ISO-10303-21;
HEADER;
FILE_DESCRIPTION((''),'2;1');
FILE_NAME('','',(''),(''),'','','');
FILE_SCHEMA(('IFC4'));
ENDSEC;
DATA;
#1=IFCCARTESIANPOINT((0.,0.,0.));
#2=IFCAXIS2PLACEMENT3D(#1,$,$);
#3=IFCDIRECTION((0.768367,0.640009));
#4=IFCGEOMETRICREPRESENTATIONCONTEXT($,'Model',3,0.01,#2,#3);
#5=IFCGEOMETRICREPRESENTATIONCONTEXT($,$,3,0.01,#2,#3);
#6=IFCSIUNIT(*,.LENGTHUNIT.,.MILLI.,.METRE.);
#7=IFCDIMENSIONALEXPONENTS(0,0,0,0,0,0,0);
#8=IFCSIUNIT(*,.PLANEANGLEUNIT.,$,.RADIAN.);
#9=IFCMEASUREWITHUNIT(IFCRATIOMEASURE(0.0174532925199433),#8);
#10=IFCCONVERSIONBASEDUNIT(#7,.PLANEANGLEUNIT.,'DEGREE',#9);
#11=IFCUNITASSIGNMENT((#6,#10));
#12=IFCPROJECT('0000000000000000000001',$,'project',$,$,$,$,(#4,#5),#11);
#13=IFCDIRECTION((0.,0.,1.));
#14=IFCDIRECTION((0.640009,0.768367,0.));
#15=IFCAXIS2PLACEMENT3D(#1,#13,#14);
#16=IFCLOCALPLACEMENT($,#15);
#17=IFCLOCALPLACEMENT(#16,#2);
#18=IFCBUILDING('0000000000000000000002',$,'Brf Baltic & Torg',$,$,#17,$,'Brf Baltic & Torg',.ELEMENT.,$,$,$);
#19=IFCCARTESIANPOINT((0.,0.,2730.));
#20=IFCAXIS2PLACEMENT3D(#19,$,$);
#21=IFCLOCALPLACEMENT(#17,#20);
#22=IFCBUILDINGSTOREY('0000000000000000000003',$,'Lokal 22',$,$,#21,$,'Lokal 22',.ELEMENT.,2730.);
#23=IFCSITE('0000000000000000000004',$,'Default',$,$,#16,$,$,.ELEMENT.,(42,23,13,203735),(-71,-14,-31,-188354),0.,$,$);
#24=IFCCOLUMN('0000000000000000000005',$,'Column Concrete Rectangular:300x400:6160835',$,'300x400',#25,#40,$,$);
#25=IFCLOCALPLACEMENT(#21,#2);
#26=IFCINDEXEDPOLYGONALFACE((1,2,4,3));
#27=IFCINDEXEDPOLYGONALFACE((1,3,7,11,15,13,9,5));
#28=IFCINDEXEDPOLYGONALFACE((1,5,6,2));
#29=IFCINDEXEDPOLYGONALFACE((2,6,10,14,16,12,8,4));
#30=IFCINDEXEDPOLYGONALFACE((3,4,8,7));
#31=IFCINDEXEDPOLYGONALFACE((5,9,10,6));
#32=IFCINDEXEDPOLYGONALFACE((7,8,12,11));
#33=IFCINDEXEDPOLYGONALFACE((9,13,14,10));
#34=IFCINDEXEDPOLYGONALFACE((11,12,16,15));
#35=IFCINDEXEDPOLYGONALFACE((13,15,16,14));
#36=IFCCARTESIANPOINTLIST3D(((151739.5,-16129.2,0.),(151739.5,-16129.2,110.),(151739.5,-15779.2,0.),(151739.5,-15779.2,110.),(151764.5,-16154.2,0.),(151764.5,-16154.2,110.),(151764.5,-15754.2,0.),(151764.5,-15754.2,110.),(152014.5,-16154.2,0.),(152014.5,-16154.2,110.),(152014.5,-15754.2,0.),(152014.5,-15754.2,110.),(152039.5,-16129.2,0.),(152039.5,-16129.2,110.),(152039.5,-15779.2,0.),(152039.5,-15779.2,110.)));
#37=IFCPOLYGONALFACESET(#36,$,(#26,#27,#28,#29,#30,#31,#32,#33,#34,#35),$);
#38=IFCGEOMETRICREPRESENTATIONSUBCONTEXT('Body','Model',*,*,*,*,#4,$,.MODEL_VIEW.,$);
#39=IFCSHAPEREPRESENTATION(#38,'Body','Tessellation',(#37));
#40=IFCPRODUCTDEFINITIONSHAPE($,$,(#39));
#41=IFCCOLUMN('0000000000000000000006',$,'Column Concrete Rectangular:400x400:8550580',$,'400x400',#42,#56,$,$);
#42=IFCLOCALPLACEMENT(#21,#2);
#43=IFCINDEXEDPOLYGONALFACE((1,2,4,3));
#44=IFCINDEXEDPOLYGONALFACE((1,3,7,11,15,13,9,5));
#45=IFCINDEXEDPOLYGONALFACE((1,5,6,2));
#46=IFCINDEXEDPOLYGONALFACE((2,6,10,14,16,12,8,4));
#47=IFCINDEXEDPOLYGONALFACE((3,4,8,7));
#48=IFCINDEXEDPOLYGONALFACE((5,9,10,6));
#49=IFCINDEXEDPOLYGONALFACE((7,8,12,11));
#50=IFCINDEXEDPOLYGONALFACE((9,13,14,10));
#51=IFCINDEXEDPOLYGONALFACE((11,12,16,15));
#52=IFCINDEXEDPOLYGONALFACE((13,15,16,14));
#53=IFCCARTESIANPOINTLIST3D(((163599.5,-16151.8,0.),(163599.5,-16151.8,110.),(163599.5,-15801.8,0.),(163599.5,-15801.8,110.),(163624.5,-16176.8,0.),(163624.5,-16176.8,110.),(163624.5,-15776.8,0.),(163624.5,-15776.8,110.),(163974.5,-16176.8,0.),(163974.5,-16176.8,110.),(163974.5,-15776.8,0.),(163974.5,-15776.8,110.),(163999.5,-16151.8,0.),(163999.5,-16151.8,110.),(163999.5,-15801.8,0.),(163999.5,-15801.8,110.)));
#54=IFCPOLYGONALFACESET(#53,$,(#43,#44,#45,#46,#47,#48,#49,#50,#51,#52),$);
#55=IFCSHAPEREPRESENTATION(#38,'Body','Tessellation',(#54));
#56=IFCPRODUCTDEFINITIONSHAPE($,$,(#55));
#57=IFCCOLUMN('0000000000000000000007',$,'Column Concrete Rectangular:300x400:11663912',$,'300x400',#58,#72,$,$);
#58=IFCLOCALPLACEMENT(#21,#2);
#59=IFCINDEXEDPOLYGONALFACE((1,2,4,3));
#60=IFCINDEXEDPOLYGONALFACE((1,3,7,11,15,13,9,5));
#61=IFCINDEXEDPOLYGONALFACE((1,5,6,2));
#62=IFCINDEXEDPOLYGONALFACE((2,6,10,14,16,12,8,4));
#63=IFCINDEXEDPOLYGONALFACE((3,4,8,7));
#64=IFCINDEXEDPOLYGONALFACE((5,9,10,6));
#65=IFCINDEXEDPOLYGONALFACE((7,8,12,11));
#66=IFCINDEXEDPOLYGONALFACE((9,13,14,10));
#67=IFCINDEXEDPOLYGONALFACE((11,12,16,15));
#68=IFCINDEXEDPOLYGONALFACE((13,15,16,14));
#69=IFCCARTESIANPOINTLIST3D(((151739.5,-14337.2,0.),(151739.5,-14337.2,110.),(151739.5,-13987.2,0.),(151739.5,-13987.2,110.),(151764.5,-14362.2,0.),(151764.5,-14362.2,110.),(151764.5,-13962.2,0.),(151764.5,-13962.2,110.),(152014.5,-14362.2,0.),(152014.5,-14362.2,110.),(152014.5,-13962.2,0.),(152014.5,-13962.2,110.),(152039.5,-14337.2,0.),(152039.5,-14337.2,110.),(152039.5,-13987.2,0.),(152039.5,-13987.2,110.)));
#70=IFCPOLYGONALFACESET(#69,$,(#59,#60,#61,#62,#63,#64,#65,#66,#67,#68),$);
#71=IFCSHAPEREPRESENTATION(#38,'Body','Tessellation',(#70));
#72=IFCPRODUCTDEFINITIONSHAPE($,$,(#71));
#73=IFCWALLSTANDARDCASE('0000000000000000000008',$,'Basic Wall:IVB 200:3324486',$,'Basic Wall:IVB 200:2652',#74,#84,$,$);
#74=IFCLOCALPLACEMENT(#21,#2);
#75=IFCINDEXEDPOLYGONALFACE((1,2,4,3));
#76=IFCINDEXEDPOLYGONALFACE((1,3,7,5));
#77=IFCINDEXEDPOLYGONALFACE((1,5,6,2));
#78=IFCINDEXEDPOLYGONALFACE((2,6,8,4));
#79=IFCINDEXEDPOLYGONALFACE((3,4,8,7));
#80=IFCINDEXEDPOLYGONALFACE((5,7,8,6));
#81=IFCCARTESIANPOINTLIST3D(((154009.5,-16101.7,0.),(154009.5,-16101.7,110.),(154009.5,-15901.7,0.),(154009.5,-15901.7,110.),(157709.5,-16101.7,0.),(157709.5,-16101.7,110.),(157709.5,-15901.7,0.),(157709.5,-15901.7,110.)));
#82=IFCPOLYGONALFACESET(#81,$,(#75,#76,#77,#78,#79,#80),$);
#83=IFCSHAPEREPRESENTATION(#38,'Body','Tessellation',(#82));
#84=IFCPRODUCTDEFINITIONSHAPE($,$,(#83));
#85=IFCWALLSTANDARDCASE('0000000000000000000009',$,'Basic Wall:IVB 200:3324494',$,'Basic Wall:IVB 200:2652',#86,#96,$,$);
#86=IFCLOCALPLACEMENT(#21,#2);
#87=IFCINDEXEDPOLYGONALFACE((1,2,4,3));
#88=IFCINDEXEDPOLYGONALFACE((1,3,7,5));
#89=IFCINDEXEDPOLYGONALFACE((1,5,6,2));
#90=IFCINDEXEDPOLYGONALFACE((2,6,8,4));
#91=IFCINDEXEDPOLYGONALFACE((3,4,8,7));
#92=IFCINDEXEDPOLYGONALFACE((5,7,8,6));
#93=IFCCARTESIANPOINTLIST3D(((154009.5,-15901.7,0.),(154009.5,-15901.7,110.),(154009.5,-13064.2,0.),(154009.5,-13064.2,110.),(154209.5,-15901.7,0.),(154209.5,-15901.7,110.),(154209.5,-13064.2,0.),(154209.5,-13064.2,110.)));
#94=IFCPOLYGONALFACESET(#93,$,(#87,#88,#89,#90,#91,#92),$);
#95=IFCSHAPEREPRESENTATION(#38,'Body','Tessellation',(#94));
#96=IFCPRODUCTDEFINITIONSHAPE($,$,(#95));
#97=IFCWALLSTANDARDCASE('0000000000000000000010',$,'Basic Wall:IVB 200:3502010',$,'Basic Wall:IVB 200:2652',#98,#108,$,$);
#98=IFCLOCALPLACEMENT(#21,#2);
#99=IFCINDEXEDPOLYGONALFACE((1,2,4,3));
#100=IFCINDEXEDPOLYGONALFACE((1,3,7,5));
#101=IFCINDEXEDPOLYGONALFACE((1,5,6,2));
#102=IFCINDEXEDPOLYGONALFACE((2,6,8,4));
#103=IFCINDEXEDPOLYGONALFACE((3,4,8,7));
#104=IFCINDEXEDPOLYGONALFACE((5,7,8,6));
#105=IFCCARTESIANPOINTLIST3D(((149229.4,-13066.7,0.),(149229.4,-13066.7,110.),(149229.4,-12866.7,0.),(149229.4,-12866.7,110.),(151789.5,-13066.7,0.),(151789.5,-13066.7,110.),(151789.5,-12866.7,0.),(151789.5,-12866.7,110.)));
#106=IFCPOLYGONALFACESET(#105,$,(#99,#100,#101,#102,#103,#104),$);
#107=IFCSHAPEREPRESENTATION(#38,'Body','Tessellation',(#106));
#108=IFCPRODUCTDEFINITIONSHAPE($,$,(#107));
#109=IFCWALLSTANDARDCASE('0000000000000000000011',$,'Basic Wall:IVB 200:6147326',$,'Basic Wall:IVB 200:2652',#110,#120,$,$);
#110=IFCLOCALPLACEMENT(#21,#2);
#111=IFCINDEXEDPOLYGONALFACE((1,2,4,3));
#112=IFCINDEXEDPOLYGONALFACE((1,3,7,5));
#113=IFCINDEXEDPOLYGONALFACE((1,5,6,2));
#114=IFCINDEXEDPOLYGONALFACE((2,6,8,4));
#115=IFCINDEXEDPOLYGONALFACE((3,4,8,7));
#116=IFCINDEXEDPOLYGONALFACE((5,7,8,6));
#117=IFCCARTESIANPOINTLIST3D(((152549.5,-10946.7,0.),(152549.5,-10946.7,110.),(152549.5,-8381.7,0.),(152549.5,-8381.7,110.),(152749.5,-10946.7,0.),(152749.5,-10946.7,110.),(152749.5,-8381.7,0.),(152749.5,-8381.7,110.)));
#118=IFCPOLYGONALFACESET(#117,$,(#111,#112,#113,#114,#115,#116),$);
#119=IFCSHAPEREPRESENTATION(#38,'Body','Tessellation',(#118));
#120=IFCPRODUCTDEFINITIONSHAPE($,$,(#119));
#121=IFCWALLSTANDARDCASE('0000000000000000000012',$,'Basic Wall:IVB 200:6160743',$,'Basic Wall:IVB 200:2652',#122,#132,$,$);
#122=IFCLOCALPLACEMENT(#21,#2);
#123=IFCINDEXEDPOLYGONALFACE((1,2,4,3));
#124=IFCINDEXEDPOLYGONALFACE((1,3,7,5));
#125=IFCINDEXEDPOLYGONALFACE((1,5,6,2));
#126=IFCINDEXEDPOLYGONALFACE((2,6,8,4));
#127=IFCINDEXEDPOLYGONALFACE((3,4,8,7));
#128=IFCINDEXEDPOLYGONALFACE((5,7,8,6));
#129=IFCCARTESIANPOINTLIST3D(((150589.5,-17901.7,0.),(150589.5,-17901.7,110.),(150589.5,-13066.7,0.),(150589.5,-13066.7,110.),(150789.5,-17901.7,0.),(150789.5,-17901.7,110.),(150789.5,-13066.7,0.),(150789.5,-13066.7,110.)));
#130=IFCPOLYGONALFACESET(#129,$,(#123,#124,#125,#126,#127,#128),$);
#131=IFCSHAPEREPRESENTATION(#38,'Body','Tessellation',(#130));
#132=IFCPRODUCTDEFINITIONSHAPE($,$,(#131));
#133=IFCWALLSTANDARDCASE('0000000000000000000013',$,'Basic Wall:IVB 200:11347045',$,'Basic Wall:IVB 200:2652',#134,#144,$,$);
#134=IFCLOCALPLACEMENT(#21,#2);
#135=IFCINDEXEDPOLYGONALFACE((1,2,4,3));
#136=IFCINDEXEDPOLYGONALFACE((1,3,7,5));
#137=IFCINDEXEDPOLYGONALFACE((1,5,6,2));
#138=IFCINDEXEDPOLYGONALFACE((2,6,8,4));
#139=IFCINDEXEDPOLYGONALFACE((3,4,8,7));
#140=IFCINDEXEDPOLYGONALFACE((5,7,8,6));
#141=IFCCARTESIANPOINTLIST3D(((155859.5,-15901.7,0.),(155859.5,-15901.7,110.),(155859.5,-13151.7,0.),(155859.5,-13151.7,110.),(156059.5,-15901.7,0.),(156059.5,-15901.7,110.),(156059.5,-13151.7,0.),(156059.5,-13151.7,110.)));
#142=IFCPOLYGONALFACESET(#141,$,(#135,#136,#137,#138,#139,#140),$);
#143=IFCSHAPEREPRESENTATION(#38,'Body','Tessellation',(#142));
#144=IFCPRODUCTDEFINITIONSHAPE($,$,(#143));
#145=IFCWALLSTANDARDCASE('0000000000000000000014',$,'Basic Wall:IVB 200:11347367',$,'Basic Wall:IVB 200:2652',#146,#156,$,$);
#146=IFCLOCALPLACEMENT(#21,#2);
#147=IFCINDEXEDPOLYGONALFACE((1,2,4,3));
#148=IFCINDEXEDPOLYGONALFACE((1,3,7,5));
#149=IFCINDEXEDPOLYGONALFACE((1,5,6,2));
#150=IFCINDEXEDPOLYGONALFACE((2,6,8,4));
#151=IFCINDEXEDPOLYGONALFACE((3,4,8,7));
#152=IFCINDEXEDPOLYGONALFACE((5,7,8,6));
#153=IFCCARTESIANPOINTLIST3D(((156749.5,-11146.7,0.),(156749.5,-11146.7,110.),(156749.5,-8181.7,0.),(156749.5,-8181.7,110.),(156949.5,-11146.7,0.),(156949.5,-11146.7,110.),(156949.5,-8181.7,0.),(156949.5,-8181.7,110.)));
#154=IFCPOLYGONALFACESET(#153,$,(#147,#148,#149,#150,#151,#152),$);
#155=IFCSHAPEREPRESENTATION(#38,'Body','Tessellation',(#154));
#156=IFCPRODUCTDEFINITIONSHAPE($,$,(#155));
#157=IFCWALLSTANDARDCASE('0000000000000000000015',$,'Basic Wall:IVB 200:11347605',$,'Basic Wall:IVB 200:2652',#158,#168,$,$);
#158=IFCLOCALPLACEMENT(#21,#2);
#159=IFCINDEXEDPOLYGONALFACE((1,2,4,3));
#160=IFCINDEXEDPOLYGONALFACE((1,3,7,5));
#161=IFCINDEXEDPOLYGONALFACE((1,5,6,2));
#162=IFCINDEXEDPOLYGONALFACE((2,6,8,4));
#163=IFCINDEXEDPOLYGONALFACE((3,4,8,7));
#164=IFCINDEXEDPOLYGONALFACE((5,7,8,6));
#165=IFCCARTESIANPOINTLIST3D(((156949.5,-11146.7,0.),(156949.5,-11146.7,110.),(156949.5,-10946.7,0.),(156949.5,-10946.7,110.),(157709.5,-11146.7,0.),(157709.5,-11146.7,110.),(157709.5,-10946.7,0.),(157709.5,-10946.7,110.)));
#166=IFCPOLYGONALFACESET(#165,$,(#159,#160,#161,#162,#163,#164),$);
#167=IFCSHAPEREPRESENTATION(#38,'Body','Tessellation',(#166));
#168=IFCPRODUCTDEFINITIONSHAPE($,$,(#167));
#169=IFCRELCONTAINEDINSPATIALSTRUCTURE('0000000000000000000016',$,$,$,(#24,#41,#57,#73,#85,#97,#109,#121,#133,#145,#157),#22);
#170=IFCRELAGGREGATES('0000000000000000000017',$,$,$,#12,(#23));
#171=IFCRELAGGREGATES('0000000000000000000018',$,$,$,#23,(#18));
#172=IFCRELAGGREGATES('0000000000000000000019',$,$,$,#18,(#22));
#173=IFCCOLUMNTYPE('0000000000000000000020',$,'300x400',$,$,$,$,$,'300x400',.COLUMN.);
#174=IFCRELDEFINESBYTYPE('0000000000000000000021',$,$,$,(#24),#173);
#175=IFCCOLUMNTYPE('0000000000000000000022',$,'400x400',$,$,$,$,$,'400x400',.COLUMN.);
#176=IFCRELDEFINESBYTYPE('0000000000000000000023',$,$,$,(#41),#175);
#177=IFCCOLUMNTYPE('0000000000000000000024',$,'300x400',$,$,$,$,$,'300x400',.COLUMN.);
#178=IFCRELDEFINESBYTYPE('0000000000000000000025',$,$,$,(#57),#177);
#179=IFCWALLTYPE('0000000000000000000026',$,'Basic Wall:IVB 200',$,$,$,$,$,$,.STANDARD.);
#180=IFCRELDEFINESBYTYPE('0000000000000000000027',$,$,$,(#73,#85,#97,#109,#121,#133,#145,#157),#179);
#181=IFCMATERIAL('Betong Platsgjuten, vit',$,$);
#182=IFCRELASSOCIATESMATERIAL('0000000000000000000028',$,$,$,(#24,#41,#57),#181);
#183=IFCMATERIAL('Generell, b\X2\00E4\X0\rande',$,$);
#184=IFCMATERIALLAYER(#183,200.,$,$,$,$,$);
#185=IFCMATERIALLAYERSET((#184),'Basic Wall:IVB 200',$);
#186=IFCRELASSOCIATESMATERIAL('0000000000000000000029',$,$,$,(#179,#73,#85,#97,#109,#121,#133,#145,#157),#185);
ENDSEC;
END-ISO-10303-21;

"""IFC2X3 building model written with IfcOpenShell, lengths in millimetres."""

from ifc_helpers import new_model, entity, si_unit, converted_unit, direction, frame, frame_2d, origin, place, context, subcontext, project, spatial, polyline, rectangle, outline, extrude, clip, halfspace, source, transform, mapped, material, layer, layer_set, layer_usage, type_object, type_shapes, element, save


model = new_model("IFC2X3")

# Units and contexts
model_context = context("Model", 3, precision=0.01, world=origin(), true_north=direction((0.768367, 0.640009)))
context_of_model = context(None, 3, precision=0.01, world=origin(), true_north=direction((0.768367, 0.640009)))
body_context = subcontext(model_context, "Body", "Model", "MODEL_VIEW")
ifc_project = project(units=[si_unit("LENGTHUNIT", "METRE", prefix="MILLI"), converted_unit("PLANEANGLEUNIT", "DEGREE", entity("IfcRatioMeasure", 0.0174532925199433), si_unit("PLANEANGLEUNIT", "RADIAN"), dimensions=[0, 0, 0, 0, 0, 0, 0])], contexts=[model_context, context_of_model])

# Site, building, storey
site_placement = place(None, frame((0.0, 0.0, 0.0), z_axis=(0.0, 0.0, 1.0), x_axis=(0.640009, 0.768367, 0.0)))
site = spatial("IfcSite", under=ifc_project, at=site_placement, Name="Default", CompositionType="ELEMENT", RefLatitude=(42, 23, 13, 203735), RefLongitude=(-71, -14, -31, -188354), RefElevation=0.0)
building_placement = place(site_placement, origin())
building = spatial("IfcBuilding", under=site, at=building_placement, Name="Brf Baltic & Torg", LongName="Brf Baltic & Torg", CompositionType="ELEMENT")
storey_placement = place(building_placement, frame((0.0, 0.0, 2730.0)))
storey = spatial("IfcBuildingStorey", under=building, at=storey_placement, Name="Lokal 22", LongName="Lokal 22", CompositionType="ELEMENT", Elevation=2730.0)

# Columns
ifc_material_1 = material(Name="Betong Platsgjuten, vit")
column_type_1 = type_object("IfcColumnType", Name="300x400", ElementType="300x400", PredefinedType="COLUMN")
shared_shape_1 = source(origin(), body_context, "Body", "SweptSolid", [
    extrude(outline(polyline([(-175.0, -150.0), (175.0, -150.0), (200.0, -125.0), (200.0, 125.0), (175.0, 150.0), (-175.0, 150.0), (-200.0, 125.0), (-200.0, -125.0), (-175.0, -150.0)])), frame((0.0, 0.0, 2730.0), z_axis=(0.0, 0.0, 1.0), x_axis=(0.0, -1.0, 0.0)), (0.0, 0.0, 1.0), 110.0),
])
type_shapes(column_type_1, [shared_shape_1])
column_1_placement = place(storey_placement, frame((151889.5, -15954.2, -2730.0)))
element("IfcColumn", 1, at=column_1_placement, inside=storey, type_object=column_type_1, material=ifc_material_1, Name="Column Concrete Rectangular:300x400:6160835", ObjectType="300x400", context=body_context, shape_type="MappedRepresentation", body=[
    mapped(shared_shape_1, transform((0.0, 0.0, 0.0), scale=1.0)),
])
column_type_2 = type_object("IfcColumnType", Name="400x400", ElementType="400x400", PredefinedType="COLUMN")
shared_shape_2 = source(origin(), body_context, "Body", "SweptSolid", [
    extrude(outline(polyline([(-175.0, -200.0), (175.0, -200.0), (200.0, -175.0), (200.0, 175.0), (175.0, 200.0), (-175.0, 200.0), (-200.0, 175.0), (-200.0, -175.0), (-175.0, -200.0)])), frame((0.0, 0.0, 2730.0), z_axis=(0.0, 0.0, 1.0), x_axis=(0.0, -1.0, 0.0)), (0.0, 0.0, 1.0), 110.0),
])
type_shapes(column_type_2, [shared_shape_2])
column_2_placement = place(storey_placement, frame((163799.5, -15976.8, -2730.0)))
element("IfcColumn", 2, at=column_2_placement, inside=storey, type_object=column_type_2, material=ifc_material_1, Name="Column Concrete Rectangular:400x400:8550580", ObjectType="400x400", context=body_context, shape_type="MappedRepresentation", body=[
    mapped(shared_shape_2, transform((0.0, 0.0, 0.0), scale=1.0)),
])
column_type_3 = type_object("IfcColumnType", Name="300x400", ElementType="300x400", PredefinedType="COLUMN")
shared_shape_3 = source(origin(), body_context, "Body", "SweptSolid", [
    extrude(outline(polyline([(-175.0, -150.0), (175.0, -150.0), (200.0, -125.0), (200.0, 125.0), (175.0, 150.0), (-175.0, 150.0), (-200.0, 125.0), (-200.0, -125.0), (-175.0, -150.0)])), frame((0.0, 0.0, 2730.0), z_axis=(0.0, 0.0, 1.0), x_axis=(0.0, -1.0, 0.0)), (0.0, 0.0, 1.0), 110.0),
])
type_shapes(column_type_3, [shared_shape_3])
column_3_placement = place(storey_placement, frame((151889.5, -14162.2, -2730.0)))
element("IfcColumn", 3, at=column_3_placement, inside=storey, type_object=column_type_3, material=ifc_material_1, Name="Column Concrete Rectangular:300x400:11663912", ObjectType="300x400", context=body_context, shape_type="MappedRepresentation", body=[
    mapped(shared_shape_3, transform((0.0, 0.0, 0.0), scale=1.0)),
])

# Walls
ifc_material_2 = material(Name="Generell, bärande")
ifc_layer = layer(ifc_material_2, 200.0)
ifc_layer_set = layer_set([ifc_layer], Name="Basic Wall:IVB 200")
ifc_layer_usage_1 = layer_usage(ifc_layer_set, "AXIS2", "NEGATIVE", 100.0)
wall_type = type_object("IfcWallType", Name="Basic Wall:IVB 200", PredefinedType="STANDARD", material=ifc_layer_set)
wall_1_placement = place(storey_placement, frame((157709.5, -16001.7, 0.0), z_axis=(0.0, 0.0, 1.0), x_axis=(-1.0, 0.0, 0.0)))
element("IfcWallStandardCase", 4, at=wall_1_placement, inside=storey, type_object=wall_type, material=ifc_layer_usage_1, Name="Basic Wall:IVB 200:3324486", ObjectType="Basic Wall:IVB 200:2652", context=body_context, shape_type="Clipping", body=[
    clip(extrude(rectangle(XDim=3700.0, YDim=200.0, at=frame_2d((1850.0, 0.0), x_axis=(-1.0, 0.0))), origin(), (0.0, 0.0, 1.0), 110.0), halfspace(frame((0.0, 0.0, -1080.0)), True)),
])
ifc_layer_usage_2 = layer_usage(ifc_layer_set, "AXIS2", "NEGATIVE", 100.0)
wall_2_placement = place(storey_placement, frame((154109.5, -15901.7, 0.0), z_axis=(0.0, 0.0, 1.0), x_axis=(0.0, 1.0, 0.0)))
element("IfcWallStandardCase", 5, at=wall_2_placement, inside=storey, type_object=wall_type, material=ifc_layer_usage_2, Name="Basic Wall:IVB 200:3324494", ObjectType="Basic Wall:IVB 200:2652", context=body_context, shape_type="Clipping", body=[
    clip(extrude(rectangle(XDim=2837.5, YDim=200.0, at=frame_2d((1418.7, 0.0), x_axis=(-1.0, 0.0))), origin(), (0.0, 0.0, 1.0), 110.0), halfspace(frame((0.0, 0.0, -1080.0)), True)),
])

# Wall
ifc_layer_usage_3 = layer_usage(ifc_layer_set, "AXIS2", "NEGATIVE", 100.0)
wall_3_placement = place(storey_placement, frame((151789.5, -12966.7, 0.0), z_axis=(0.0, 0.0, 1.0), x_axis=(-1.0, 0.0, 0.0)))
element("IfcWallStandardCase", 6, at=wall_3_placement, inside=storey, type_object=wall_type, material=ifc_layer_usage_3, Name="Basic Wall:IVB 200:3502010", ObjectType="Basic Wall:IVB 200:2652", context=body_context, shape_type="Clipping", body=[
    clip(extrude(rectangle(XDim=2560.1, YDim=200.0, at=frame_2d((1280.0, 0.0), x_axis=(-1.0, 0.0))), origin(), (0.0, 0.0, 1.0), 110.0), halfspace(frame((0.0, 0.0, -1080.0)), True)),
])

# Walls
ifc_layer_usage_4 = layer_usage(ifc_layer_set, "AXIS2", "NEGATIVE", 100.0)
wall_4_placement = place(storey_placement, frame((152649.5, -10946.7, 0.0), z_axis=(0.0, 0.0, 1.0), x_axis=(0.0, 1.0, 0.0)))
element("IfcWallStandardCase", 7, at=wall_4_placement, inside=storey, type_object=wall_type, material=ifc_layer_usage_4, Name="Basic Wall:IVB 200:6147326", ObjectType="Basic Wall:IVB 200:2652", context=body_context, shape_type="Clipping", body=[
    clip(extrude(rectangle(XDim=2565.0, YDim=200.0, at=frame_2d((1282.5, 0.0), x_axis=(-1.0, 0.0))), origin(), (0.0, 0.0, 1.0), 110.0), halfspace(frame((0.0, 0.0, -1080.0)), True)),
])
ifc_layer_usage_5 = layer_usage(ifc_layer_set, "AXIS2", "POSITIVE", -100.0)
wall_5_placement = place(storey_placement, frame((150689.5, -13066.7, 0.0), z_axis=(0.0, 0.0, 1.0), x_axis=(0.0, -1.0, 0.0)))
element("IfcWallStandardCase", 8, at=wall_5_placement, inside=storey, type_object=wall_type, material=ifc_layer_usage_5, Name="Basic Wall:IVB 200:6160743", ObjectType="Basic Wall:IVB 200:2652", context=body_context, shape_type="Clipping", body=[
    clip(extrude(rectangle(XDim=4835.0, YDim=200.0, at=frame_2d((2417.5, 0.0), x_axis=(-1.0, 0.0))), origin(), (0.0, 0.0, 1.0), 110.0), halfspace(frame((0.0, 0.0, -1080.0)), True)),
])
ifc_layer_usage_6 = layer_usage(ifc_layer_set, "AXIS2", "NEGATIVE", 100.0)
wall_6_placement = place(storey_placement, frame((155959.5, -15901.7, 0.0), z_axis=(0.0, 0.0, 1.0), x_axis=(0.0, 1.0, 0.0)))
element("IfcWallStandardCase", 9, at=wall_6_placement, inside=storey, type_object=wall_type, material=ifc_layer_usage_6, Name="Basic Wall:IVB 200:11347045", ObjectType="Basic Wall:IVB 200:2652", context=body_context, shape_type="Clipping", body=[
    clip(extrude(rectangle(XDim=2750.0, YDim=200.0, at=frame_2d((1375.0, 0.0), x_axis=(-1.0, 0.0))), origin(), (0.0, 0.0, 1.0), 110.0), halfspace(frame((0.0, 0.0, -1080.0)), True)),
])
ifc_layer_usage_7 = layer_usage(ifc_layer_set, "AXIS2", "POSITIVE", -100.0)
wall_7_placement = place(storey_placement, frame((156849.5, -8181.7, 0.0), z_axis=(0.0, 0.0, 1.0), x_axis=(0.0, -1.0, 0.0)))
element("IfcWallStandardCase", 10, at=wall_7_placement, inside=storey, type_object=wall_type, material=ifc_layer_usage_7, Name="Basic Wall:IVB 200:11347367", ObjectType="Basic Wall:IVB 200:2652", context=body_context, shape_type="Clipping", body=[
    clip(extrude(rectangle(XDim=2965.0, YDim=200.0, at=frame_2d((1482.5, 0.0), x_axis=(-1.0, 0.0))), origin(), (0.0, 0.0, 1.0), 110.0), halfspace(frame((0.0, 0.0, -1080.0)), True)),
])
ifc_layer_usage_8 = layer_usage(ifc_layer_set, "AXIS2", "NEGATIVE", 100.0)
wall_8_placement = place(storey_placement, frame((156949.5, -11046.7, 0.0)))
element("IfcWallStandardCase", 11, at=wall_8_placement, inside=storey, type_object=wall_type, material=ifc_layer_usage_8, Name="Basic Wall:IVB 200:11347605", ObjectType="Basic Wall:IVB 200:2652", context=body_context, shape_type="Clipping", body=[
    clip(extrude(rectangle(XDim=760.0, YDim=200.0, at=frame_2d((380.0, 0.0), x_axis=(-1.0, 0.0))), origin(), (0.0, 0.0, 1.0), 110.0), halfspace(frame((0.0, 0.0, -1080.0)), True)),
])

save(model, "model.ifc")
